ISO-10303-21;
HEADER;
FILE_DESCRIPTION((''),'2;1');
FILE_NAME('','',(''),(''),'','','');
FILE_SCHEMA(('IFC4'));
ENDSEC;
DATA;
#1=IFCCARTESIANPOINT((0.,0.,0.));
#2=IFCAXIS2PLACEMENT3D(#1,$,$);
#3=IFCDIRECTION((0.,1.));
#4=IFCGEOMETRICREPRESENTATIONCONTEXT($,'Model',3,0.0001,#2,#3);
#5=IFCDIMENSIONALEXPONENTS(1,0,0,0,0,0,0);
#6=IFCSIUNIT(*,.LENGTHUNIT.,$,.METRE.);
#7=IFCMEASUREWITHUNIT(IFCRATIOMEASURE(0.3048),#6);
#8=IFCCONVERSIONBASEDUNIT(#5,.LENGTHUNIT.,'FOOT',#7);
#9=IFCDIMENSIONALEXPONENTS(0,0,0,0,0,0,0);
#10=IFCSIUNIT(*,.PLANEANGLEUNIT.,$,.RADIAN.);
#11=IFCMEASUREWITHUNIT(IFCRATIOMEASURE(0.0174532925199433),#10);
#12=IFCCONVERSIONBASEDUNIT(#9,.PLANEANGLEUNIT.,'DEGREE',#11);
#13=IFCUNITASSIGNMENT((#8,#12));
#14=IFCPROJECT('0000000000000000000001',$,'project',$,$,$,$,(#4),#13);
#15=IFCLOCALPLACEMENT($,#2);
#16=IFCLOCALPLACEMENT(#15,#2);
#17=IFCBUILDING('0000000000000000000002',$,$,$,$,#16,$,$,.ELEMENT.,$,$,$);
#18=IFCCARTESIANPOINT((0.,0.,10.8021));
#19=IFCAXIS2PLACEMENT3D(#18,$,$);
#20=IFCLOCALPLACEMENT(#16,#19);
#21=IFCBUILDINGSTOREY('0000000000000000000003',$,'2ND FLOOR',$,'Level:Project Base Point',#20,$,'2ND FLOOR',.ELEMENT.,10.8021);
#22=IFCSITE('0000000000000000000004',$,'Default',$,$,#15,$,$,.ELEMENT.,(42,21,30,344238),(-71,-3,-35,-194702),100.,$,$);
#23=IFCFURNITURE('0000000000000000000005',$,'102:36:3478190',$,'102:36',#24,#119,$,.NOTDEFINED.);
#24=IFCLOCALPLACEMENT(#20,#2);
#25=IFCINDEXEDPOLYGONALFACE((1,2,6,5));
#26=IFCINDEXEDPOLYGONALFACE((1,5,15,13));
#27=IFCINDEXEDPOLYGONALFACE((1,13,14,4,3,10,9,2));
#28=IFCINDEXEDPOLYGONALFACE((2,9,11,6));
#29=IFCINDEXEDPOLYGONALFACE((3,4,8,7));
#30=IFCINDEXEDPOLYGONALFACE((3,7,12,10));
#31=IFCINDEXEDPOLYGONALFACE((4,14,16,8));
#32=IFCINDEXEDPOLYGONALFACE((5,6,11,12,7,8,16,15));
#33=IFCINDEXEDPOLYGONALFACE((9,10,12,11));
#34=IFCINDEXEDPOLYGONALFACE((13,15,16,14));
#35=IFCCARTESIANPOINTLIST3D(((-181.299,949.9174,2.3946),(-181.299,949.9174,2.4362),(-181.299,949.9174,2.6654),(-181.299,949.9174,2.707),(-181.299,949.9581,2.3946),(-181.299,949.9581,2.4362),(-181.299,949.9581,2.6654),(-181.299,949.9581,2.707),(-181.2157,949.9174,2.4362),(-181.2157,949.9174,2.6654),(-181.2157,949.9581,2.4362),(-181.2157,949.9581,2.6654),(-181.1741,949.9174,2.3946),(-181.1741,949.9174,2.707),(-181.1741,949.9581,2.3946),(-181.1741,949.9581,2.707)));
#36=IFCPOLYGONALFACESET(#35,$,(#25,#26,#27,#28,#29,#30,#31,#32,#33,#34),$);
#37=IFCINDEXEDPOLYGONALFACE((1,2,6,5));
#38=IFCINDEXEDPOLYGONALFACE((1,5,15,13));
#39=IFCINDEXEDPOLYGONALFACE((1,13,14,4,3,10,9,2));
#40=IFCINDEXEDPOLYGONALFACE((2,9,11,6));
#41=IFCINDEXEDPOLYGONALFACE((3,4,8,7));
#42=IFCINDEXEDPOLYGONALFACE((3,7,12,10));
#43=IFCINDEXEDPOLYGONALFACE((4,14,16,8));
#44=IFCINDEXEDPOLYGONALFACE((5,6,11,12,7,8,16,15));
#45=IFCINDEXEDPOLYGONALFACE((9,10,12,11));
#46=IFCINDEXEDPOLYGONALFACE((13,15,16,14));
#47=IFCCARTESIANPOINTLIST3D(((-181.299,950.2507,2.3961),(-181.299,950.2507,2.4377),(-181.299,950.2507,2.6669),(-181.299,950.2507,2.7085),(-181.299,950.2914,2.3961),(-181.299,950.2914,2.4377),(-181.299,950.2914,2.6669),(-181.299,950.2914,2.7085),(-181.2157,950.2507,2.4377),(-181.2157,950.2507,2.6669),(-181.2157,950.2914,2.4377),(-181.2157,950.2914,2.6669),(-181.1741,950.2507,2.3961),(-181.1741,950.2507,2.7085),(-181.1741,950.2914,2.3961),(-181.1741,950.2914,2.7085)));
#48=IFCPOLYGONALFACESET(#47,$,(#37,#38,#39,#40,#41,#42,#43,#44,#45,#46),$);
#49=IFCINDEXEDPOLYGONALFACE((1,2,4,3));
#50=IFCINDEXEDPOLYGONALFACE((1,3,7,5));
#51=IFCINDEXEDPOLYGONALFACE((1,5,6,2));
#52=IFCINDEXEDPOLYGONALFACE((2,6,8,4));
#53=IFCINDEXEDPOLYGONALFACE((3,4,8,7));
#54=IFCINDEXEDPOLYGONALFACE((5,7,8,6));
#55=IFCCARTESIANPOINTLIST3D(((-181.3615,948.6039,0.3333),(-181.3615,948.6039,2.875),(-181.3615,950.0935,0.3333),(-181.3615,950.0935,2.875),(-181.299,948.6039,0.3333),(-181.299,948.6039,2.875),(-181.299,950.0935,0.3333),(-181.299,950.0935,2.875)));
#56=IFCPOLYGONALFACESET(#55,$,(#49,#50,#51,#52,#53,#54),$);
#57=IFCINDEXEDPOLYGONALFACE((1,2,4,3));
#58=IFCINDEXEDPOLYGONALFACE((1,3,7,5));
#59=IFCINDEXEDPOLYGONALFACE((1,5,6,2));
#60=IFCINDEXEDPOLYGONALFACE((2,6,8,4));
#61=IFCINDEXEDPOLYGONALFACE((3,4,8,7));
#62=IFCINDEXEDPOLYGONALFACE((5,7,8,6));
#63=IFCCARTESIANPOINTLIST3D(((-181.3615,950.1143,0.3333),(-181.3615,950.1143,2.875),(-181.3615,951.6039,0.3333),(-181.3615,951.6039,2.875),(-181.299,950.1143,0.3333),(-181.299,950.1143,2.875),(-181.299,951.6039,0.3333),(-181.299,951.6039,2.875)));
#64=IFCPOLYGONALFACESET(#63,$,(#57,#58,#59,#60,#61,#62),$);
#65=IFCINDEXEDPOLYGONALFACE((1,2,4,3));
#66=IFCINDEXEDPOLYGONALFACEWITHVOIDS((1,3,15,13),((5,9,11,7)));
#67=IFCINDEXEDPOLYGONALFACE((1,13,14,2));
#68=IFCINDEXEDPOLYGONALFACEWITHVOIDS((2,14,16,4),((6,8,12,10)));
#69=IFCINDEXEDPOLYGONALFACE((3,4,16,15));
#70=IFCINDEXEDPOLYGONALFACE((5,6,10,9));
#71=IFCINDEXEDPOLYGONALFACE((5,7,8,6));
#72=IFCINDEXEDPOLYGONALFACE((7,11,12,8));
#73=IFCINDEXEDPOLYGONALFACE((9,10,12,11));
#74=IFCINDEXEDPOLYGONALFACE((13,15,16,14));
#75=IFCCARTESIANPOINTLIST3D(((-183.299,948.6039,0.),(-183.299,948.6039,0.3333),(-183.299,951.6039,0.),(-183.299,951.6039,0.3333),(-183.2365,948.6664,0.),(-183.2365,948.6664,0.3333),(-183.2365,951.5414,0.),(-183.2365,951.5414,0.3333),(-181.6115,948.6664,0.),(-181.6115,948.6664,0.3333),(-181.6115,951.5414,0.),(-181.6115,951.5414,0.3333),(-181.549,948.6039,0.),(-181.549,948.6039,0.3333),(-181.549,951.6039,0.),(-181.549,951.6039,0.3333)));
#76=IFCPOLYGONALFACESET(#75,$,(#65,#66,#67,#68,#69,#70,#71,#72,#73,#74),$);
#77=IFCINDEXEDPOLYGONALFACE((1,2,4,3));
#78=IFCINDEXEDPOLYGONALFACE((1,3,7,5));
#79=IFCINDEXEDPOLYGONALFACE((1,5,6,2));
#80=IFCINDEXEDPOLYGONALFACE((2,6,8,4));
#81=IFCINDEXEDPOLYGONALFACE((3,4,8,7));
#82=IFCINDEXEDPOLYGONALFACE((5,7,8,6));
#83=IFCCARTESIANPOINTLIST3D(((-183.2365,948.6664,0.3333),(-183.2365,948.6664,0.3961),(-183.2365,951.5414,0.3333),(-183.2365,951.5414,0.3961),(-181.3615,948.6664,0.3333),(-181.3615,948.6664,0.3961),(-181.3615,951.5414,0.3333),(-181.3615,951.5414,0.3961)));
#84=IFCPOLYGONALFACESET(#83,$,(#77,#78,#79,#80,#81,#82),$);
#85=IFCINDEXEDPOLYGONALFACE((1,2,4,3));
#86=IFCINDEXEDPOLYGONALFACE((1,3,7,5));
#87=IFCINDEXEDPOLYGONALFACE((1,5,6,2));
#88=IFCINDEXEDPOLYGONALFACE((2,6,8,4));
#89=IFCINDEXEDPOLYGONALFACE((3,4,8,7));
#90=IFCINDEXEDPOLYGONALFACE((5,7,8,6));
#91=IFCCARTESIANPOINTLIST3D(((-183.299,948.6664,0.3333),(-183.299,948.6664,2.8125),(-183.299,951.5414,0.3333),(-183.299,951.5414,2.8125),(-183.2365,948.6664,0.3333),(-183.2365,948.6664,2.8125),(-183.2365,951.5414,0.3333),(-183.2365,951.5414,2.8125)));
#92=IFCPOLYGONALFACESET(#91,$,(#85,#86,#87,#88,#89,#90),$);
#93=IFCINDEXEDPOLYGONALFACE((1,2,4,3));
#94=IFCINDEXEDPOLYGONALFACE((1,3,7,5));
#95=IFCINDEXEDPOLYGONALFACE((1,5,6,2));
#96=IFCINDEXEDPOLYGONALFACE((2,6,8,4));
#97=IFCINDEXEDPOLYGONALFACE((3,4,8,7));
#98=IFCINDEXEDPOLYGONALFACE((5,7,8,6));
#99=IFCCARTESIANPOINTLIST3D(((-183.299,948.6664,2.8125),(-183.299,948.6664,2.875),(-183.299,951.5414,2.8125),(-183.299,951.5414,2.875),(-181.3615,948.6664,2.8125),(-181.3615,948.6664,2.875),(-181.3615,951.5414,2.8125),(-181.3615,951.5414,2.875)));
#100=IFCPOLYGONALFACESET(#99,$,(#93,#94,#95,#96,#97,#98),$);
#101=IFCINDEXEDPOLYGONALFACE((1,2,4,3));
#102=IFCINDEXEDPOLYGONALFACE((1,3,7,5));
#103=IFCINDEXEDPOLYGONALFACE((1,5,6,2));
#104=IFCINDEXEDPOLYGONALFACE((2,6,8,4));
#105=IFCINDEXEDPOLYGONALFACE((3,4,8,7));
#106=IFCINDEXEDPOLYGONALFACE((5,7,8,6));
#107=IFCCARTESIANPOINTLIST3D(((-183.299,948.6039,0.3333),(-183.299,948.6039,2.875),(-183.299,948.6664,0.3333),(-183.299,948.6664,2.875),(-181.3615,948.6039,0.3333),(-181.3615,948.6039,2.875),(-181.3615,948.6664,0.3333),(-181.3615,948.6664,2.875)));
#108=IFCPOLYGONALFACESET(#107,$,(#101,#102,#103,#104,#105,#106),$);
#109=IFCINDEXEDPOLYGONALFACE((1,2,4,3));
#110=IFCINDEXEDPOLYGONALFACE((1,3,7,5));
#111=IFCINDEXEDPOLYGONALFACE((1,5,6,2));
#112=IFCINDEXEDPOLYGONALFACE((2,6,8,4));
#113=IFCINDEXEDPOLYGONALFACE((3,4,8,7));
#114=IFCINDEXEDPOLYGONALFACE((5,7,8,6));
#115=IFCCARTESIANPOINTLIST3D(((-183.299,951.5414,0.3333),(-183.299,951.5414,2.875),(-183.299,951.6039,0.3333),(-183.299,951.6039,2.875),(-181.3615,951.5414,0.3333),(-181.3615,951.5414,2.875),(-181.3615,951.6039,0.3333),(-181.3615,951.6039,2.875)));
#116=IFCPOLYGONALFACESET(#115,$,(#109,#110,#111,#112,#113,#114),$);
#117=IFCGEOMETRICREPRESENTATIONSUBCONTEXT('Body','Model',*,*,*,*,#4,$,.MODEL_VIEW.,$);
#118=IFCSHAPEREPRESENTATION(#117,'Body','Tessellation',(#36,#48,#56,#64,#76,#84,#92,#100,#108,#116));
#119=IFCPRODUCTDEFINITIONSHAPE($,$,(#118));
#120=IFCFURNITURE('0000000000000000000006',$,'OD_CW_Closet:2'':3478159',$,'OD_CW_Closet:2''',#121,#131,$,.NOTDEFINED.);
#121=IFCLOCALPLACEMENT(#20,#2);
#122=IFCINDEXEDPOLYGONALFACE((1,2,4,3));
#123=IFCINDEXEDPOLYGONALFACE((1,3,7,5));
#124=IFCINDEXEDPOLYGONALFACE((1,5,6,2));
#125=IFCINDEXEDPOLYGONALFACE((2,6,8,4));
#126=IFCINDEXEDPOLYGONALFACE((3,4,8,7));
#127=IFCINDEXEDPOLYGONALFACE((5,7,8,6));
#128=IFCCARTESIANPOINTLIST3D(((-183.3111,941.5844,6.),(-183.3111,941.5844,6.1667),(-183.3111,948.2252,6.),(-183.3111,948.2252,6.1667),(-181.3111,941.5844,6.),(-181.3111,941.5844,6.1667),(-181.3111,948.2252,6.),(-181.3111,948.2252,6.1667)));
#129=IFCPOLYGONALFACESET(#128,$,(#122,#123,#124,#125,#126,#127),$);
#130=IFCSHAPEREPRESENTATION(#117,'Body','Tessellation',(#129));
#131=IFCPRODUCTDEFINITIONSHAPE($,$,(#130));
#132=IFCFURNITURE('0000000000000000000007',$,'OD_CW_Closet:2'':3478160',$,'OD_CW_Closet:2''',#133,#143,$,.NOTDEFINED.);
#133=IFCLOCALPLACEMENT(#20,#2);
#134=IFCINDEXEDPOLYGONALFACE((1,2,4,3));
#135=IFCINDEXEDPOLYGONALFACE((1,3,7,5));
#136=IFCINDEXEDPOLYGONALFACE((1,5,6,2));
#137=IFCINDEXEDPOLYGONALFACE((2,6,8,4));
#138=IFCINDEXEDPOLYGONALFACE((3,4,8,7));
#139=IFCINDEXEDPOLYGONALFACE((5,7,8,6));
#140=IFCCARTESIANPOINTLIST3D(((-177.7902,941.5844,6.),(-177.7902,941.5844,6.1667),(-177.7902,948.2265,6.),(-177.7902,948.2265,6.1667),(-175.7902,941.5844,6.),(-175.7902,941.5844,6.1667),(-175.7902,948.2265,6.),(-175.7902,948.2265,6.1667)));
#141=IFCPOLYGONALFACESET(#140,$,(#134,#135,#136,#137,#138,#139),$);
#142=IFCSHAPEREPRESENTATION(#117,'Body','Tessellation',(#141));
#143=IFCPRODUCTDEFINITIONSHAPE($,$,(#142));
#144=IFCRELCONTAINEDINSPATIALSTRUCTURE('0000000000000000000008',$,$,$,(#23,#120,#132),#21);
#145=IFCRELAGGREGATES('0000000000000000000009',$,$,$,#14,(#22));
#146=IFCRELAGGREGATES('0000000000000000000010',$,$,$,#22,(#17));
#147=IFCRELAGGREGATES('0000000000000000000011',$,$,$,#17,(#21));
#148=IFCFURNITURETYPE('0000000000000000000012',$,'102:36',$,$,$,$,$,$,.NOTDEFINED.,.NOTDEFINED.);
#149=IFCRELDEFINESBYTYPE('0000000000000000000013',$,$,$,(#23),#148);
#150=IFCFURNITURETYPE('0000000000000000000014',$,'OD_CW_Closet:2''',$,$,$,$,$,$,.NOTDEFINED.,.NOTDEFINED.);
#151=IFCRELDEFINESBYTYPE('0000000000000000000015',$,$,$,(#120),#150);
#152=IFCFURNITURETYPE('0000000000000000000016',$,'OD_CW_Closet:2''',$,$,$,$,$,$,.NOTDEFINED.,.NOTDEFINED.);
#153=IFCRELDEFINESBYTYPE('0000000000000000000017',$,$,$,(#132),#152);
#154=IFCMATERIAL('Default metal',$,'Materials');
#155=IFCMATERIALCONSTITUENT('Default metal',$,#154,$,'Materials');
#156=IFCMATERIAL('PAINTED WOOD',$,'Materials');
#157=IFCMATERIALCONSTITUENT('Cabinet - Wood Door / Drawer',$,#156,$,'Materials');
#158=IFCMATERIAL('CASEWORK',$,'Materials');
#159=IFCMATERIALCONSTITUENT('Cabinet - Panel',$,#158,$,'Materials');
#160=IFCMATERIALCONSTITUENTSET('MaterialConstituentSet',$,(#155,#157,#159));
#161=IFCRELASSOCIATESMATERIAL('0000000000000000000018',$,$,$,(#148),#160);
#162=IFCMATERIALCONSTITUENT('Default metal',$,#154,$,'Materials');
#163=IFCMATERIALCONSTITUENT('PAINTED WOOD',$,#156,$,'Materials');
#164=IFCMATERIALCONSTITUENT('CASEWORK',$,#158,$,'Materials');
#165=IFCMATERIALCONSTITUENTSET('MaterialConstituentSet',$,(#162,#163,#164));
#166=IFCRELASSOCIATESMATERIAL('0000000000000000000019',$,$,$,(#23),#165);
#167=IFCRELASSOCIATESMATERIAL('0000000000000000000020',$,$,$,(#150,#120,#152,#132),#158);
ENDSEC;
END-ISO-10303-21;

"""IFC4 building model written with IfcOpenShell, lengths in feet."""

from ifc_helpers import new_model, entity, si_unit, converted_unit, direction, frame, frame_2d, origin, origin_2d_with_axis, place, context, subcontext, project, spatial, polyline, rectangle, outline, extrude, source, transform, mapped, material, constituent, constituent_set, type_object, type_shapes, element, save


model = new_model("IFC4")

# Units and contexts
model_context = context("Model", 3, precision=0.0001, world=origin(), true_north=direction((0.0, 1.0)))
body_context = subcontext(model_context, "Body", "Model", "MODEL_VIEW")
ifc_project = project(units=[converted_unit("LENGTHUNIT", "FOOT", entity("IfcRatioMeasure", 0.3048), si_unit("LENGTHUNIT", "METRE"), dimensions=[1, 0, 0, 0, 0, 0, 0]), converted_unit("PLANEANGLEUNIT", "DEGREE", entity("IfcRatioMeasure", 0.0174532925199433), si_unit("PLANEANGLEUNIT", "RADIAN"), dimensions=[0, 0, 0, 0, 0, 0, 0])], contexts=[model_context])

# Site, building, storey
site_placement = place(None, origin())
site = spatial("IfcSite", under=ifc_project, at=site_placement, Name="Default", CompositionType="ELEMENT", RefLatitude=(42, 21, 30, 344238), RefLongitude=(-71, -3, -35, -194702), RefElevation=100.0)
building_placement = place(site_placement, origin())
building = spatial("IfcBuilding", under=site, at=building_placement, CompositionType="ELEMENT")
storey_placement = place(building_placement, frame((0.0, 0.0, 10.8021)))
storey = spatial("IfcBuildingStorey", under=building, at=storey_placement, Name="2ND FLOOR", ObjectType="Level:Project Base Point", LongName="2ND FLOOR", CompositionType="ELEMENT", Elevation=10.8021)

# Furniture
ifc_material_1 = material(Name="Default metal", Category="Materials")
ifc_material_2 = material(Name="PAINTED WOOD", Category="Materials")
ifc_material_3 = material(Name="CASEWORK", Category="Materials")
ifc_constituent_1 = constituent(ifc_material_1, Name="Default metal", Category="Materials")
ifc_constituent_2 = constituent(ifc_material_2, Name="PAINTED WOOD", Category="Materials")
ifc_constituent_3 = constituent(ifc_material_3, Name="CASEWORK", Category="Materials")
ifc_constituent_set_1 = constituent_set(constituents=[ifc_constituent_1, ifc_constituent_2, ifc_constituent_3], Name="MaterialConstituentSet")
ifc_constituent_4 = constituent(ifc_material_1, Name="Default metal", Category="Materials")
ifc_constituent_5 = constituent(ifc_material_2, Name="Cabinet - Wood Door / Drawer", Category="Materials")
ifc_constituent_6 = constituent(ifc_material_3, Name="Cabinet - Panel", Category="Materials")
ifc_constituent_set_2 = constituent_set(constituents=[ifc_constituent_4, ifc_constituent_5, ifc_constituent_6], Name="MaterialConstituentSet")
furniture_type_1 = type_object("IfcFurnitureType", Name="102:36", AssemblyPlace="NOTDEFINED", PredefinedType="NOTDEFINED", material=ifc_constituent_set_2)
shared_shape_1 = source(origin(), body_context, "Body", "SweptSolid", [
    extrude(outline(polyline([(-0.0521, -0.1146), (-0.0521, -0.1562), (0.0729, -0.1562), (0.0729, 0.1562), (-0.0521, 0.1562), (-0.0521, 0.1146), (0.0313, 0.1146), (0.0313, -0.1146), (-0.0521, -0.1146)])), frame((0.2073, 2.0521, 2.5508), z_axis=(-1.0, 0.0, 0.0), x_axis=(0.0, 1.0, 0.0)), (0.0, 0.0, -1.0), 0.0407),
    extrude(outline(polyline([(-0.0521, -0.1146), (-0.0521, -0.1562), (0.0729, -0.1562), (0.0729, 0.1562), (-0.0521, 0.1562), (-0.0521, 0.1146), (0.0313, 0.1146), (0.0313, -0.1146), (-0.0521, -0.1146)])), frame((-0.126, 2.0521, 2.5523), z_axis=(-1.0, 0.0, 0.0), x_axis=(0.0, 1.0, 0.0)), (0.0, 0.0, -1.0), 0.0407),
    extrude(rectangle(XDim=1.4896, YDim=0.0625, at=frame_2d((0.0, 0.0), x_axis=(1.0, 0.0))), frame((0.8167, 1.9688, 0.3333), z_axis=(0.0, 0.0, 1.0), x_axis=(-1.0, 0.0, 0.0)), (0.0, 0.0, 1.0), 2.5417),
    extrude(rectangle(XDim=1.4896, YDim=0.0625, at=origin_2d_with_axis()), frame((-0.6937, 1.9688, 0.3333), z_axis=(0.0, 0.0, 1.0), x_axis=(-1.0, 0.0, 0.0)), (0.0, 0.0, 1.0), 2.5417),
    extrude(outline(polyline([(-0.875, -1.5), (0.875, -1.5), (0.875, 1.5), (-0.875, 1.5), (-0.875, -1.5)]), holes=[polyline([(-0.8125, -1.4375), (-0.8125, 1.4375), (0.8125, 1.4375), (0.8125, -1.4375), (-0.8125, -1.4375)])]), frame((0.0615, 0.875, 0.0), z_axis=(0.0, 0.0, 1.0), x_axis=(0.0, -1.0, 0.0)), (0.0, 0.0, 1.0), 0.3333),
    extrude(rectangle(XDim=1.875, YDim=2.875, at=origin_2d_with_axis()), frame((0.0615, 1.0, 0.3333), z_axis=(0.0, 0.0, 1.0), x_axis=(0.0, 1.0, 0.0)), (0.0, 0.0, 1.0), 0.0627),
    extrude(rectangle(XDim=2.875, YDim=0.0625, at=origin_2d_with_axis()), frame((0.0615, 0.0312, 0.3333), z_axis=(0.0, 0.0, 1.0), x_axis=(-1.0, 0.0, 0.0)), (0.0, 0.0, 1.0), 2.4792),
    extrude(rectangle(XDim=1.9375, YDim=2.875, at=frame_2d((0.0, 0.0), x_axis=(1.0, 0.0))), frame((0.0615, 0.9688, 2.8125), z_axis=(0.0, 0.0, 1.0), x_axis=(0.0, 1.0, 0.0)), (0.0, 0.0, 1.0), 0.0625),
    extrude(rectangle(XDim=1.9375, YDim=0.0625, at=frame_2d((0.0, 0.0), x_axis=(1.0, 0.0))), frame((1.5302, 0.9687, 0.3333), z_axis=(0.0, 0.0, 1.0), x_axis=(0.0, -1.0, 0.0)), (0.0, 0.0, 1.0), 2.5417),
    extrude(rectangle(XDim=1.9375, YDim=0.0625, at=frame_2d((0.0, 0.0), x_axis=(1.0, 0.0))), frame((-1.4073, 0.9687, 0.3333), z_axis=(0.0, 0.0, 1.0), x_axis=(0.0, -1.0, 0.0)), (0.0, 0.0, 1.0), 2.5417),
])
type_shapes(furniture_type_1, [shared_shape_1])
furniture_1_placement = place(storey_placement, frame((-183.299, 950.1654, 0.0), z_axis=(0.0, 0.0, 1.0), x_axis=(0.0, -1.0, 0.0)))
element("IfcFurniture", 1, at=furniture_1_placement, inside=storey, type_object=furniture_type_1, material=ifc_constituent_set_1, Name="102:36:3478190", ObjectType="102:36", PredefinedType="NOTDEFINED", context=body_context, shape_type="MappedRepresentation", body=[
    mapped(shared_shape_1, transform((0.0, 0.0, 0.0), scale=1.0)),
])
furniture_type_2 = type_object("IfcFurnitureType", Name="OD_CW_Closet:2'", AssemblyPlace="NOTDEFINED", PredefinedType="NOTDEFINED", material=ifc_material_3)
shared_shape_2 = source(origin(), body_context, "Body", "SweptSolid", [
    extrude(rectangle(XDim=6.6407, YDim=2.0, at=origin_2d_with_axis()), frame((3.3204, 1.0, 0.0)), (0.0, 0.0, 1.0), 0.1667),
])
type_shapes(furniture_type_2, [shared_shape_2])
furniture_2_placement = place(storey_placement, frame((-183.3111, 948.2252, 6.0), z_axis=(0.0, 0.0, 1.0), x_axis=(0.0, -1.0, 0.0)))
element("IfcFurniture", 2, at=furniture_2_placement, inside=storey, type_object=furniture_type_2, material=ifc_material_3, Name="OD_CW_Closet:2':3478159", ObjectType="OD_CW_Closet:2'", PredefinedType="NOTDEFINED", context=body_context, shape_type="MappedRepresentation", body=[
    mapped(shared_shape_2, transform((0.0, 0.0, 0.0), scale=1.0)),
])
furniture_type_3 = type_object("IfcFurnitureType", Name="OD_CW_Closet:2'", AssemblyPlace="NOTDEFINED", PredefinedType="NOTDEFINED", material=ifc_material_3)
shared_shape_3 = source(origin(), body_context, "Body", "SweptSolid", [
    extrude(rectangle(XDim=2.0, YDim=6.6421, at=origin_2d_with_axis()), frame((3.3211, 1.0, 0.0), z_axis=(0.0, 0.0, 1.0), x_axis=(0.0, -1.0, 0.0)), (0.0, 0.0, 1.0), 0.1667),
])
type_shapes(furniture_type_3, [shared_shape_3])
furniture_3_placement = place(storey_placement, frame((-177.7902, 948.2265, 6.0), z_axis=(0.0, 0.0, 1.0), x_axis=(0.0, -1.0, 0.0)))
element("IfcFurniture", 3, at=furniture_3_placement, inside=storey, type_object=furniture_type_3, material=ifc_material_3, Name="OD_CW_Closet:2':3478160", ObjectType="OD_CW_Closet:2'", PredefinedType="NOTDEFINED", context=body_context, shape_type="MappedRepresentation", body=[
    mapped(shared_shape_3, transform((0.0, 0.0, 0.0), scale=1.0)),
])

save(model, "model.ifc")
